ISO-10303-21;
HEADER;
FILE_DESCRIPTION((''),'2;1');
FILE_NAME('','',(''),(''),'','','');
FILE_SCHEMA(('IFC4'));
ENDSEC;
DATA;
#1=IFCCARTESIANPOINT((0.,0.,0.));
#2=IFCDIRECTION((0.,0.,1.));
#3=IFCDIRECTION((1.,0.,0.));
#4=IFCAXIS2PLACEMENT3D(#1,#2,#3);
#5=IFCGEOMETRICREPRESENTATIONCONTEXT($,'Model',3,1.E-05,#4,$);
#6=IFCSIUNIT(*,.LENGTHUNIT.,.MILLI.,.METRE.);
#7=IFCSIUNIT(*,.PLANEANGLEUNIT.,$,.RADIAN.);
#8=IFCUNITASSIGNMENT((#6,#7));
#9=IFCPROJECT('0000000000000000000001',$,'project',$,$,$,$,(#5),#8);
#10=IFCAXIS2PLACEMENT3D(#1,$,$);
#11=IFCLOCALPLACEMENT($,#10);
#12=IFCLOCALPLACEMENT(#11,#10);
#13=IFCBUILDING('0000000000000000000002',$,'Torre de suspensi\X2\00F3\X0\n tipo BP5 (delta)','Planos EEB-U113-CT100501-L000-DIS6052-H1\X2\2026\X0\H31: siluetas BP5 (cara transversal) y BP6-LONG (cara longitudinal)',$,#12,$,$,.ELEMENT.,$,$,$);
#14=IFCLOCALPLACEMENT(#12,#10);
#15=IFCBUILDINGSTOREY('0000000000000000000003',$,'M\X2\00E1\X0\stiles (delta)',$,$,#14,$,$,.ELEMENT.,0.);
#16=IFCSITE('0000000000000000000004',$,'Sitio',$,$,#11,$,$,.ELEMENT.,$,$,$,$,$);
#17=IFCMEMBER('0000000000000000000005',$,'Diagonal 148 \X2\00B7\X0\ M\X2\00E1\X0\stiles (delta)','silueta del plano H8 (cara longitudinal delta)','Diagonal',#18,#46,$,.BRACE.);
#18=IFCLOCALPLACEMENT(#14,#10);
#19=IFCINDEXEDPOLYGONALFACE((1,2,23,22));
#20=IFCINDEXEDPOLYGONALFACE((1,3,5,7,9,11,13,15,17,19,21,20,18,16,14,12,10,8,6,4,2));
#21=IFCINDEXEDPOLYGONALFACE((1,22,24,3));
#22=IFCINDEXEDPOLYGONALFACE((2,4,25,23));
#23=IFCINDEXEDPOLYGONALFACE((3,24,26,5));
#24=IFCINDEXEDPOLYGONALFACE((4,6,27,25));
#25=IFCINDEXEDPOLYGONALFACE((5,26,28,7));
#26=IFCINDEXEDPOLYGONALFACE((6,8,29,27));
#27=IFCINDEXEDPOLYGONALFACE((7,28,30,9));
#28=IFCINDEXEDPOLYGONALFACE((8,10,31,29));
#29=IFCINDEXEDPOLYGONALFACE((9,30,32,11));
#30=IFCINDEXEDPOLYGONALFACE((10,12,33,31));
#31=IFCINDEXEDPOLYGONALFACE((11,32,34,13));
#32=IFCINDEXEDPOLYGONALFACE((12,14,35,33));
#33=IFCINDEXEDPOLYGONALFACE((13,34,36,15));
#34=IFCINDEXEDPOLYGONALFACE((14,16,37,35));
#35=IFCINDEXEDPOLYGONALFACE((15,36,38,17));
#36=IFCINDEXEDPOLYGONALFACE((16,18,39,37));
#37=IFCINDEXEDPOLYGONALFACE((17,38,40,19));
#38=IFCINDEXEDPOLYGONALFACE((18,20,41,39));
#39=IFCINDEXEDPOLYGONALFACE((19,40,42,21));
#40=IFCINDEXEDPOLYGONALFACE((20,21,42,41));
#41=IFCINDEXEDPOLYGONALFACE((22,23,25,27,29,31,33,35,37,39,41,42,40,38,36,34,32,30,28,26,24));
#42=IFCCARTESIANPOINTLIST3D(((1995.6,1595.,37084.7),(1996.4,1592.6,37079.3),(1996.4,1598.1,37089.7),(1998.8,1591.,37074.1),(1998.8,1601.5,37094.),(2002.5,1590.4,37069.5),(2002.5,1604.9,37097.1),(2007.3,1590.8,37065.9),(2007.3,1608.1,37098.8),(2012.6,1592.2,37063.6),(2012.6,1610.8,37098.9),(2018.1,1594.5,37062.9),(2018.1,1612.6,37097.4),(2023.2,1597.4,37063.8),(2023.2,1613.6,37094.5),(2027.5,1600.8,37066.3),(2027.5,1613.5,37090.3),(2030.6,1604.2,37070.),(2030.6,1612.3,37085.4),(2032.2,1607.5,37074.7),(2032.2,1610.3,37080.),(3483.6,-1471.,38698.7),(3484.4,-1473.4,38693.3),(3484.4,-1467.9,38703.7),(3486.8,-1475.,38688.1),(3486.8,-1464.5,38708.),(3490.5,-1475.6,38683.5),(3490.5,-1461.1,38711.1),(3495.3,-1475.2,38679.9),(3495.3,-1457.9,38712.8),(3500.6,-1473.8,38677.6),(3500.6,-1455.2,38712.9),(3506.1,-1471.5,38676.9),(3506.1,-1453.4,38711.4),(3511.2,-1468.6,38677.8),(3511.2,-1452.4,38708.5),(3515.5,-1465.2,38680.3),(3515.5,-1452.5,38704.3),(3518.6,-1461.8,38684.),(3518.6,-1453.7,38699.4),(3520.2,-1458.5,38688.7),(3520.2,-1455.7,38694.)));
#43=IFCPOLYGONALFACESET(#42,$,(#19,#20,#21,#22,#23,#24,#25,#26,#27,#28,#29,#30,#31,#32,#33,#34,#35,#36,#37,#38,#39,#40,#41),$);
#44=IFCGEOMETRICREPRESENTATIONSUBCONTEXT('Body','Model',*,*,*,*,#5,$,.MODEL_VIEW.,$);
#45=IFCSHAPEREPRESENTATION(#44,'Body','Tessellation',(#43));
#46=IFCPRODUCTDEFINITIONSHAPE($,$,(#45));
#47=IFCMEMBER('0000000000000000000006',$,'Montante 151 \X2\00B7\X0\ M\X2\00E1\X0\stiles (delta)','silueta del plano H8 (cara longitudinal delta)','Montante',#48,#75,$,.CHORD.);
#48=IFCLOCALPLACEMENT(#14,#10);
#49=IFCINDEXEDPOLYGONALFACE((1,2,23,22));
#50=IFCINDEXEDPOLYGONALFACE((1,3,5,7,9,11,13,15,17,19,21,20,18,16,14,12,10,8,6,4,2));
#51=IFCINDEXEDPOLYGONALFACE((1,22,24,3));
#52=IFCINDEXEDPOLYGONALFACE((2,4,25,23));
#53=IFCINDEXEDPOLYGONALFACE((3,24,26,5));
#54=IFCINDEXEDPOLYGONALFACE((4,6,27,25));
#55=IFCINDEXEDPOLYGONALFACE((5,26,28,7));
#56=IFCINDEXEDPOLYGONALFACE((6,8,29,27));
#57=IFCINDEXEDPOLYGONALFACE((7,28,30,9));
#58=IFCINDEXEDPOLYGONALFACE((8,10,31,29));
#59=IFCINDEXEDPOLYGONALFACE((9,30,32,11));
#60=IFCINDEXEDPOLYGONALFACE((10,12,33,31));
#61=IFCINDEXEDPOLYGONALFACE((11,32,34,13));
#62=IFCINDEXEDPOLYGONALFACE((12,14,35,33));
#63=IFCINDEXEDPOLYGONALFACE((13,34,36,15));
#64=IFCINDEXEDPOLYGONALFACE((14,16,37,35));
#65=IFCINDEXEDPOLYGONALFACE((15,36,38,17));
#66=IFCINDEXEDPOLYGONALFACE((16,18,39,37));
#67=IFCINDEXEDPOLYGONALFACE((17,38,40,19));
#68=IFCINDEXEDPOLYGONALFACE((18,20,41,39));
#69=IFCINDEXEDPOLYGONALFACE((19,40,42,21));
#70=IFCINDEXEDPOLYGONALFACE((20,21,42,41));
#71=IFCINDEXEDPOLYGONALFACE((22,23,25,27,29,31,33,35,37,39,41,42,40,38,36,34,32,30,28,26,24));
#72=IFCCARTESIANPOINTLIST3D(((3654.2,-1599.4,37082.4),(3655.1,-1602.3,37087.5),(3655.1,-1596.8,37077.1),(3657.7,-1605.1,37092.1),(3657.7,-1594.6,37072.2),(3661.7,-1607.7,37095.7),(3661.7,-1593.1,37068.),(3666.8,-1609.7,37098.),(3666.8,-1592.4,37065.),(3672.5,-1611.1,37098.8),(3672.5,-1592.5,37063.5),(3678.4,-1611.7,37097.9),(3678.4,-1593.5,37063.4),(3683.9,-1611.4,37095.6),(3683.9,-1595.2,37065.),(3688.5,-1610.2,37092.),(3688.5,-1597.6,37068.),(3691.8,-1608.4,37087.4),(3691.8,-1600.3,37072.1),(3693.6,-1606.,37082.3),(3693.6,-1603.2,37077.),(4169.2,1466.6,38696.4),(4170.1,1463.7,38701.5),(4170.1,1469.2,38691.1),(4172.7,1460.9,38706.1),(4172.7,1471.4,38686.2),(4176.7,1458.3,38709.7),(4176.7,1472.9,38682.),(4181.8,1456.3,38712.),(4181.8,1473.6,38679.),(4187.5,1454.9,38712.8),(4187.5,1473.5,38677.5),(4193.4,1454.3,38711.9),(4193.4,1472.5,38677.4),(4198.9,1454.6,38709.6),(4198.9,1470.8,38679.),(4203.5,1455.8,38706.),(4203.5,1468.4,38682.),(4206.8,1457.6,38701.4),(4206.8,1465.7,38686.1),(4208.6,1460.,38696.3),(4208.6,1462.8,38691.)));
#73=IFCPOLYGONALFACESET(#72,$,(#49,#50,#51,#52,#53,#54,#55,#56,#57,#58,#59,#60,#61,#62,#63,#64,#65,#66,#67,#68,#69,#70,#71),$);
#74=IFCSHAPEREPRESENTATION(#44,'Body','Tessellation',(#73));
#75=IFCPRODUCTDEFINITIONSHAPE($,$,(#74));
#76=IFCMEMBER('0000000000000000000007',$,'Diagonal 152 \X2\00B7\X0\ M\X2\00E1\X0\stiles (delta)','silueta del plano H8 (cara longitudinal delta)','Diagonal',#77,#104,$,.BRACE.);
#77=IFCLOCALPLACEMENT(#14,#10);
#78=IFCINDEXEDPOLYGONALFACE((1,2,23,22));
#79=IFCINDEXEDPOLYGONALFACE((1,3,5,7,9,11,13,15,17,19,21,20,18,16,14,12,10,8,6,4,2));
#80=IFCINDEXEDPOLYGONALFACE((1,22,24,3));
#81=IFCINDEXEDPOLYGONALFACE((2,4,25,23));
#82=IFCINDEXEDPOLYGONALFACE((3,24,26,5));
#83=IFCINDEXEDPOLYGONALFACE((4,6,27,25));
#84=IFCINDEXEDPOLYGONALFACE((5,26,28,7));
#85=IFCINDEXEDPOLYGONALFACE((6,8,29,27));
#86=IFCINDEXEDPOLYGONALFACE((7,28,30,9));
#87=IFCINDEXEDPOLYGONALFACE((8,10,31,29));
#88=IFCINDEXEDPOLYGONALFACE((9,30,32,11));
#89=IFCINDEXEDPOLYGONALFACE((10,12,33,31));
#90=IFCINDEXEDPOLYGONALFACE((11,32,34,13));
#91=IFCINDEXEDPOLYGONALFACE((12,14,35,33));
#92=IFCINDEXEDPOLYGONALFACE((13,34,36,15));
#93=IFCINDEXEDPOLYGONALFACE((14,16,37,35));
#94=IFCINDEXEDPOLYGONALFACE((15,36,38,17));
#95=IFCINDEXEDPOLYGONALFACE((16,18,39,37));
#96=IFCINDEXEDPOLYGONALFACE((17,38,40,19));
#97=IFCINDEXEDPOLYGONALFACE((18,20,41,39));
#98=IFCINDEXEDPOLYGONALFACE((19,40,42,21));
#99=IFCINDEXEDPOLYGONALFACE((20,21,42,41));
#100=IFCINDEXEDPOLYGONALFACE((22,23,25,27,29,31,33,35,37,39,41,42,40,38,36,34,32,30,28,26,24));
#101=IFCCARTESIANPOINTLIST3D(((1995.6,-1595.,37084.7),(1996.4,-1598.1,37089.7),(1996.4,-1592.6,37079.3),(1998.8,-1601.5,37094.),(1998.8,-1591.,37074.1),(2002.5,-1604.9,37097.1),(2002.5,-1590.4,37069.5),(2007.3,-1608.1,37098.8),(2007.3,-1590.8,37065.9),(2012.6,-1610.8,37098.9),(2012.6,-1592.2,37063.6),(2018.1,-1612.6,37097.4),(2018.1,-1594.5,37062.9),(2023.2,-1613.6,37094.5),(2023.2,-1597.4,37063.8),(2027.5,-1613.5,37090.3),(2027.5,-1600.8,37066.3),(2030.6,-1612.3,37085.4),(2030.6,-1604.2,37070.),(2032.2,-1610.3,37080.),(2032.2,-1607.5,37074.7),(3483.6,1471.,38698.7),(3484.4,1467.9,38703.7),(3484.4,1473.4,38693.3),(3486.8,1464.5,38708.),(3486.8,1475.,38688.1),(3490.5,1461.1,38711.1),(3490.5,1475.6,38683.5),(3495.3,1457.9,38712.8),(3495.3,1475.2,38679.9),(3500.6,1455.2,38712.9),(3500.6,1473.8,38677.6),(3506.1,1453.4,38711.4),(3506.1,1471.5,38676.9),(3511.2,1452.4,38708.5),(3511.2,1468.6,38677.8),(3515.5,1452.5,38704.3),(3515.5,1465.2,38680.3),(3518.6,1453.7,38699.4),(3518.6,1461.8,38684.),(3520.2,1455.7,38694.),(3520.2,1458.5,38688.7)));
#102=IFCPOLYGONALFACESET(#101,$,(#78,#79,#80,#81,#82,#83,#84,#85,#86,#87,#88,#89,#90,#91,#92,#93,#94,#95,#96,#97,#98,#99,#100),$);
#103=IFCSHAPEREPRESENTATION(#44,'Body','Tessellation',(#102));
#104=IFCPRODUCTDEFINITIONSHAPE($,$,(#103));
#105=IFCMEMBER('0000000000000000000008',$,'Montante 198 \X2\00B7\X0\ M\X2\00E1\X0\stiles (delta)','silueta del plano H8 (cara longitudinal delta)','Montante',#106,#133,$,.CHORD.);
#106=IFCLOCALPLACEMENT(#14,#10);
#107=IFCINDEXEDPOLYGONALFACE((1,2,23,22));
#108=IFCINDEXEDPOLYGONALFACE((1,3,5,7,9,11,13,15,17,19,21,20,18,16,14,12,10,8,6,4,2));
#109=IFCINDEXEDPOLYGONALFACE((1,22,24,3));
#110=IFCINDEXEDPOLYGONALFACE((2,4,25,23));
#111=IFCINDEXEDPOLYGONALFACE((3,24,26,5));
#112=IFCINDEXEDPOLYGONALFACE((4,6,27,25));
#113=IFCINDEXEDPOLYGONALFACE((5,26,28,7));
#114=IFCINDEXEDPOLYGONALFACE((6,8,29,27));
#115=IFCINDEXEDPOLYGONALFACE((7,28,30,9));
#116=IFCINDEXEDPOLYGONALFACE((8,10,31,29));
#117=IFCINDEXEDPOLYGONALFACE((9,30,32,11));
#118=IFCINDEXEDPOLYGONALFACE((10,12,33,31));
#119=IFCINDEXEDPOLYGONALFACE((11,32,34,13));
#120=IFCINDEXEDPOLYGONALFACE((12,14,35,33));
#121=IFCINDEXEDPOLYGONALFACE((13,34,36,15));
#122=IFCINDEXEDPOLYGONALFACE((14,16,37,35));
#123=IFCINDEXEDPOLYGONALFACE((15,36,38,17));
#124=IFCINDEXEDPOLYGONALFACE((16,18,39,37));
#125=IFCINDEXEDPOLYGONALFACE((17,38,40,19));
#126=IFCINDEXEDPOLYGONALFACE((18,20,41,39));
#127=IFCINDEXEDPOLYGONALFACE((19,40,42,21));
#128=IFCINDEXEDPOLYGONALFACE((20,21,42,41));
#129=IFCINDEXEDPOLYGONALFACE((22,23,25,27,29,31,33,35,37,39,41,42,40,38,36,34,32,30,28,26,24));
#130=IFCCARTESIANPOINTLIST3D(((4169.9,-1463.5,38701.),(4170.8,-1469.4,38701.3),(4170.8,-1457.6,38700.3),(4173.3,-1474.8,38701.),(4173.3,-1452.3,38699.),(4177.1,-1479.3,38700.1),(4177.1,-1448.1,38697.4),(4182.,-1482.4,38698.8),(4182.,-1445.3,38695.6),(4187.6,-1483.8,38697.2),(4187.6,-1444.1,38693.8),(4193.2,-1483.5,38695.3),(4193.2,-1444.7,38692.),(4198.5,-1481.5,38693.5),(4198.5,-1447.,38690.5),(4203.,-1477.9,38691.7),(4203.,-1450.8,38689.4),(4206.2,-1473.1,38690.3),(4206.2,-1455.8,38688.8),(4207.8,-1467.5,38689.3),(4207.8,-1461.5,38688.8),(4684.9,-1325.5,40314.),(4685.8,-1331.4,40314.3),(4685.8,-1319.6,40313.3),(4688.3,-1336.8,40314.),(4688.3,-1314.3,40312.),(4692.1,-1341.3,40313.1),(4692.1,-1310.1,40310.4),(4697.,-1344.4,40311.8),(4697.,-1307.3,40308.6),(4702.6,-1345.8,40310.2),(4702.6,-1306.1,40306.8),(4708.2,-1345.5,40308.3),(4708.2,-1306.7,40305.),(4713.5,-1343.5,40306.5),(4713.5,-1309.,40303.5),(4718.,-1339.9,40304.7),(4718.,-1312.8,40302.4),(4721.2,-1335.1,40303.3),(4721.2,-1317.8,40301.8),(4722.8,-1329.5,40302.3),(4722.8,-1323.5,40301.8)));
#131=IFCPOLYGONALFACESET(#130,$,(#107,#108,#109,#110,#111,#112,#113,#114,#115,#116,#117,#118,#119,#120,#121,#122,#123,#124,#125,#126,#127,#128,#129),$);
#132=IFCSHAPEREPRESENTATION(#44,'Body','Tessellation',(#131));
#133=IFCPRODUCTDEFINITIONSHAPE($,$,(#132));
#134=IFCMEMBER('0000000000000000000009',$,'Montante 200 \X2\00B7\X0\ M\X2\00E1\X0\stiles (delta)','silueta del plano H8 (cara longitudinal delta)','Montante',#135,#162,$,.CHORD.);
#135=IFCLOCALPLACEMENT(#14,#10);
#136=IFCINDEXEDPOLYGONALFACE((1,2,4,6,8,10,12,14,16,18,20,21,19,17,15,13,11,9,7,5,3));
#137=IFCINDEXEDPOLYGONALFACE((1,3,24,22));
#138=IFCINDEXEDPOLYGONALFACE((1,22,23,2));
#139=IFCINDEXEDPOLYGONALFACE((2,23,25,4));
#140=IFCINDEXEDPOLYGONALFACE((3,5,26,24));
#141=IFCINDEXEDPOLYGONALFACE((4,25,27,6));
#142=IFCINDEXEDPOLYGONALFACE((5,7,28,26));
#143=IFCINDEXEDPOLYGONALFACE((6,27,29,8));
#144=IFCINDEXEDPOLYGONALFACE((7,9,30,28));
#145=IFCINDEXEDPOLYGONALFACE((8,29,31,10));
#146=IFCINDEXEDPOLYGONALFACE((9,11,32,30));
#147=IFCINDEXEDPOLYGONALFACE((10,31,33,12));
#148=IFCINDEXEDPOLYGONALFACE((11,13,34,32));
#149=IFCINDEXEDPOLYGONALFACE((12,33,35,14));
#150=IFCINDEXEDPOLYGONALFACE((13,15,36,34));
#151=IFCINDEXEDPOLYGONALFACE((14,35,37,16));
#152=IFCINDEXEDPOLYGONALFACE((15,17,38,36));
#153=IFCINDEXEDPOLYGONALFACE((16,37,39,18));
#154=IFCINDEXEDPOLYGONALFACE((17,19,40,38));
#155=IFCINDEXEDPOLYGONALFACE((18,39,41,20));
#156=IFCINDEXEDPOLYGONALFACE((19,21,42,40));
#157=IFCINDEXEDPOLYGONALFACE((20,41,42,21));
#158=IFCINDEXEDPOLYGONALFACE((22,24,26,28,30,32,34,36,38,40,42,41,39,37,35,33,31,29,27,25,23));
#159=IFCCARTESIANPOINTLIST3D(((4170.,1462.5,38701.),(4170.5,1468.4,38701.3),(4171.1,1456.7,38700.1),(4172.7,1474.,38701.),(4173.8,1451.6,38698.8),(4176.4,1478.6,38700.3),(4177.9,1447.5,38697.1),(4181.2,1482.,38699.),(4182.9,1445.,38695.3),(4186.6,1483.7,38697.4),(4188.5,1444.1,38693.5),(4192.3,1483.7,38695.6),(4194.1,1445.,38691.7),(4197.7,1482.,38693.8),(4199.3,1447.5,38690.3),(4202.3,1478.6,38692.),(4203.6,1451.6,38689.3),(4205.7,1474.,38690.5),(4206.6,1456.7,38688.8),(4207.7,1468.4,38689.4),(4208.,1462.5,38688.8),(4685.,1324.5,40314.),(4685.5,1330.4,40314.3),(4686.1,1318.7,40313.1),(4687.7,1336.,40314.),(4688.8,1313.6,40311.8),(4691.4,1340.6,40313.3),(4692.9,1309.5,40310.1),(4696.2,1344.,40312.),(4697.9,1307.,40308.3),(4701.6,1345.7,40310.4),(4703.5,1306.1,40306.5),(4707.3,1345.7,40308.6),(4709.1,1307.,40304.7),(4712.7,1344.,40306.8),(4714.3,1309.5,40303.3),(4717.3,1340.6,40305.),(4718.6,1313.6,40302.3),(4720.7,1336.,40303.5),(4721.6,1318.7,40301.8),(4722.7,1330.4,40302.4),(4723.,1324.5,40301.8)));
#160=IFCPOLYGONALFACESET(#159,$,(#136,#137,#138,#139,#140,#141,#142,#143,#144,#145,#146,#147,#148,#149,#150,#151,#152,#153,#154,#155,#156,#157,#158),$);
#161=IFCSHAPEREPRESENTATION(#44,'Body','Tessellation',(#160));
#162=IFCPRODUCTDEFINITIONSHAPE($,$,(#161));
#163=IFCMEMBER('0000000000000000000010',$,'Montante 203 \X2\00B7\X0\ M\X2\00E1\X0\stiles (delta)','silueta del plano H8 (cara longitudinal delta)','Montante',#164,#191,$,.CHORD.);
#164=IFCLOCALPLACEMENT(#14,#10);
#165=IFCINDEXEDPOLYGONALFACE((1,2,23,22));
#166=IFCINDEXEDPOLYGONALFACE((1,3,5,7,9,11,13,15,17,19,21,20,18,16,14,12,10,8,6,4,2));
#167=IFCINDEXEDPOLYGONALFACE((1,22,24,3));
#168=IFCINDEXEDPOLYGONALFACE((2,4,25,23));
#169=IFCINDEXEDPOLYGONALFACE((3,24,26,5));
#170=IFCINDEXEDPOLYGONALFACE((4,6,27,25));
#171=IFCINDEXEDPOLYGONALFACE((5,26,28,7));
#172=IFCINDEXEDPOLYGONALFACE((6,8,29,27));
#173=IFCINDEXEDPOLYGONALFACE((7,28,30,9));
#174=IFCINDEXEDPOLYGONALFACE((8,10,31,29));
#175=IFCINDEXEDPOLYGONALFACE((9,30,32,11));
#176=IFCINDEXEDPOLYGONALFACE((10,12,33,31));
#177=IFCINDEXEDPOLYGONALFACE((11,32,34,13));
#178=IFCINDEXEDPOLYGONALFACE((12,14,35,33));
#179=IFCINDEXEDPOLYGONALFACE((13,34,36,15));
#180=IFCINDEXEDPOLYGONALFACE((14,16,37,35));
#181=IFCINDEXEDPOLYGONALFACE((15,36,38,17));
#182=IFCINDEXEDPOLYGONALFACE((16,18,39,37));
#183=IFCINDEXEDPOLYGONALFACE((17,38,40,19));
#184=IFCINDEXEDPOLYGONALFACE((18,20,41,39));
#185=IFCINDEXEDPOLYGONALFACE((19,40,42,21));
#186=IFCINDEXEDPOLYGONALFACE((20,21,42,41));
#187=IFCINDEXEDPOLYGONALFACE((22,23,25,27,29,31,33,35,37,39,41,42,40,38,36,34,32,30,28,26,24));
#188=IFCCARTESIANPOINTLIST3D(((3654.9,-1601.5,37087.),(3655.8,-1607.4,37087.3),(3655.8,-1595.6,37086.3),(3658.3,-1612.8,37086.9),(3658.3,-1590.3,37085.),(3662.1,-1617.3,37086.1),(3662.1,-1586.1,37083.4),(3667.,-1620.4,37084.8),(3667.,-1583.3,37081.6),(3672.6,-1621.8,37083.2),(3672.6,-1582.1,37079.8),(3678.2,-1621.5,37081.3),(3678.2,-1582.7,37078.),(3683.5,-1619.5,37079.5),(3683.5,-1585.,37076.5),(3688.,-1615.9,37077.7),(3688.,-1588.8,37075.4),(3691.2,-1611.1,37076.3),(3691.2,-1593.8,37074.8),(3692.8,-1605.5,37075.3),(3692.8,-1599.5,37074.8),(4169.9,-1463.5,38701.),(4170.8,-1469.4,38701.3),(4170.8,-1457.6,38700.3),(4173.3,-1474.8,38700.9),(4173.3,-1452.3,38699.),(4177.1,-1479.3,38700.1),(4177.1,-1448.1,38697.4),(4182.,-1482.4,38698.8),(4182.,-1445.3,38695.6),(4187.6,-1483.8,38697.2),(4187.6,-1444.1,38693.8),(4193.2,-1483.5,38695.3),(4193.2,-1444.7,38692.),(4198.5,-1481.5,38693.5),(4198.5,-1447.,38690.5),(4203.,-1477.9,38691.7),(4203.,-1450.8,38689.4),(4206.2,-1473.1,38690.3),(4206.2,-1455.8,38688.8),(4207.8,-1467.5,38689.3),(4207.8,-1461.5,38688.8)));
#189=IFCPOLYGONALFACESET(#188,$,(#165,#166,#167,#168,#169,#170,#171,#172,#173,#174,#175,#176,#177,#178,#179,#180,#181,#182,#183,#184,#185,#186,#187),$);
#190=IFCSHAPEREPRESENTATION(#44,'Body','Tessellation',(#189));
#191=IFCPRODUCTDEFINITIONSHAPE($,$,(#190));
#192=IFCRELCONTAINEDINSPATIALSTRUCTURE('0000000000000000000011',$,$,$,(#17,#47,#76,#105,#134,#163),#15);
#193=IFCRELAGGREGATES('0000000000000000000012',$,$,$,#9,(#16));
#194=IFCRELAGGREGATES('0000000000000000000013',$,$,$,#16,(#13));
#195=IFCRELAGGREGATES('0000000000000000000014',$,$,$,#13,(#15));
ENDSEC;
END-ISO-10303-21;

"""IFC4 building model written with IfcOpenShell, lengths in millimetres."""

from ifc_helpers import new_model, si_unit, frame, origin, origin_with_axes, place, context, subcontext, project, spatial, circle, extrude, element, save


model = new_model("IFC4")

# Units and contexts
model_context = context("Model", 3, precision=1e-05, world=origin_with_axes())
body_context = subcontext(model_context, "Body", "Model", "MODEL_VIEW")
ifc_project = project(units=[si_unit("LENGTHUNIT", "METRE", prefix="MILLI"), si_unit("PLANEANGLEUNIT", "RADIAN")], contexts=[model_context])

# Site, building, storey
site_placement = place(None, origin())
site = spatial("IfcSite", under=ifc_project, at=site_placement, Name="Sitio", CompositionType="ELEMENT")
building_placement = place(site_placement, origin())
building = spatial("IfcBuilding", under=site, at=building_placement, Name="Torre de suspensión tipo BP5 (delta)", Description="Planos EEB-U113-CT100501-L000-DIS6052-H1…H31: siluetas BP5 (cara transversal) y BP6-LONG (cara longitudinal)", CompositionType="ELEMENT")
storey_placement = place(building_placement, origin())
storey = spatial("IfcBuildingStorey", under=building, at=storey_placement, Name="Mástiles (delta)", CompositionType="ELEMENT", Elevation=0.0)

# Members
member_1_placement = place(storey_placement, frame((3502.0, -1464.0, 38695.0), z_axis=(-0.394603, 0.813074, -0.428017), x_axis=(-0.918852, -0.349177, 0.183813)))
element("IfcMember", 1, at=member_1_placement, inside=storey, Name="Diagonal 148 · Mástiles (delta)", Description="silueta del plano H8 (cara longitudinal delta)", ObjectType="Diagonal", PredefinedType="BRACE", context=body_context, shape_type="SweptSolid", body=[
    extrude(circle(Radius=20.0), None, (0.0, 0.0, 1.0), 3770.9),
])
member_2_placement = place(storey_placement, frame((4189.0, 1464.0, 38695.0), z_axis=(-0.147019, -0.875265, -0.460756), x_axis=(-0.989134, 0.130095, 0.068484)))
element("IfcMember", 2, at=member_2_placement, inside=storey, Name="Montante 151 · Mástiles (delta)", Description="silueta del plano H8 (cara longitudinal delta)", ObjectType="Montante", PredefinedType="CHORD", context=body_context, shape_type="SweptSolid", body=[
    extrude(circle(Radius=20.0), None, (0.0, 0.0, 1.0), 3502.9),
])
member_3_placement = place(storey_placement, frame((3502.0, 1464.0, 38695.0), z_axis=(-0.394603, -0.813074, -0.428017), x_axis=(-0.918852, 0.349177, 0.183813)))
element("IfcMember", 3, at=member_3_placement, inside=storey, Name="Diagonal 152 · Mástiles (delta)", Description="silueta del plano H8 (cara longitudinal delta)", ObjectType="Diagonal", PredefinedType="BRACE", context=body_context, shape_type="SweptSolid", body=[
    extrude(circle(Radius=20.0), None, (0.0, 0.0, 1.0), 3770.9),
])
for number, where, z_axis, x_axis, name in (
    (4, (4704.0, -1326.0, 40308.0), (-0.303149, -0.081232, -0.949475), (-0.952943, 0.025841, 0.302046), "Montante 198 · Mástiles (delta)"),
    (5, (4704.0, 1326.0, 40308.0), (-0.303149, 0.081232, -0.949475), (-0.024707, -0.996695, -0.077384), "Montante 200 · Mástiles (delta)"),
):
    element("IfcMember", number, at=place(storey_placement, frame(where, z_axis=z_axis, x_axis=x_axis)), inside=storey, Name=name, Description="silueta del plano H8 (cara longitudinal delta)", ObjectType="Montante", PredefinedType="CHORD", context=body_context, shape_type="SweptSolid", body=[
        extrude(circle(Radius=20.0), None, (0.0, 0.0, 1.0), 1698.8),
    ])
member_4_placement = place(storey_placement, frame((4189.0, -1464.0, 38695.0), z_axis=(-0.30298, -0.081187, -0.949533), x_axis=(-0.952997, 0.025811, 0.301878)))
element("IfcMember", 6, at=member_4_placement, inside=storey, Name="Montante 203 · Mástiles (delta)", Description="silueta del plano H8 (cara longitudinal delta)", ObjectType="Montante", PredefinedType="CHORD", context=body_context, shape_type="SweptSolid", body=[
    extrude(circle(Radius=20.0), None, (0.0, 0.0, 1.0), 1699.8),
])

save(model, "model.ifc")
